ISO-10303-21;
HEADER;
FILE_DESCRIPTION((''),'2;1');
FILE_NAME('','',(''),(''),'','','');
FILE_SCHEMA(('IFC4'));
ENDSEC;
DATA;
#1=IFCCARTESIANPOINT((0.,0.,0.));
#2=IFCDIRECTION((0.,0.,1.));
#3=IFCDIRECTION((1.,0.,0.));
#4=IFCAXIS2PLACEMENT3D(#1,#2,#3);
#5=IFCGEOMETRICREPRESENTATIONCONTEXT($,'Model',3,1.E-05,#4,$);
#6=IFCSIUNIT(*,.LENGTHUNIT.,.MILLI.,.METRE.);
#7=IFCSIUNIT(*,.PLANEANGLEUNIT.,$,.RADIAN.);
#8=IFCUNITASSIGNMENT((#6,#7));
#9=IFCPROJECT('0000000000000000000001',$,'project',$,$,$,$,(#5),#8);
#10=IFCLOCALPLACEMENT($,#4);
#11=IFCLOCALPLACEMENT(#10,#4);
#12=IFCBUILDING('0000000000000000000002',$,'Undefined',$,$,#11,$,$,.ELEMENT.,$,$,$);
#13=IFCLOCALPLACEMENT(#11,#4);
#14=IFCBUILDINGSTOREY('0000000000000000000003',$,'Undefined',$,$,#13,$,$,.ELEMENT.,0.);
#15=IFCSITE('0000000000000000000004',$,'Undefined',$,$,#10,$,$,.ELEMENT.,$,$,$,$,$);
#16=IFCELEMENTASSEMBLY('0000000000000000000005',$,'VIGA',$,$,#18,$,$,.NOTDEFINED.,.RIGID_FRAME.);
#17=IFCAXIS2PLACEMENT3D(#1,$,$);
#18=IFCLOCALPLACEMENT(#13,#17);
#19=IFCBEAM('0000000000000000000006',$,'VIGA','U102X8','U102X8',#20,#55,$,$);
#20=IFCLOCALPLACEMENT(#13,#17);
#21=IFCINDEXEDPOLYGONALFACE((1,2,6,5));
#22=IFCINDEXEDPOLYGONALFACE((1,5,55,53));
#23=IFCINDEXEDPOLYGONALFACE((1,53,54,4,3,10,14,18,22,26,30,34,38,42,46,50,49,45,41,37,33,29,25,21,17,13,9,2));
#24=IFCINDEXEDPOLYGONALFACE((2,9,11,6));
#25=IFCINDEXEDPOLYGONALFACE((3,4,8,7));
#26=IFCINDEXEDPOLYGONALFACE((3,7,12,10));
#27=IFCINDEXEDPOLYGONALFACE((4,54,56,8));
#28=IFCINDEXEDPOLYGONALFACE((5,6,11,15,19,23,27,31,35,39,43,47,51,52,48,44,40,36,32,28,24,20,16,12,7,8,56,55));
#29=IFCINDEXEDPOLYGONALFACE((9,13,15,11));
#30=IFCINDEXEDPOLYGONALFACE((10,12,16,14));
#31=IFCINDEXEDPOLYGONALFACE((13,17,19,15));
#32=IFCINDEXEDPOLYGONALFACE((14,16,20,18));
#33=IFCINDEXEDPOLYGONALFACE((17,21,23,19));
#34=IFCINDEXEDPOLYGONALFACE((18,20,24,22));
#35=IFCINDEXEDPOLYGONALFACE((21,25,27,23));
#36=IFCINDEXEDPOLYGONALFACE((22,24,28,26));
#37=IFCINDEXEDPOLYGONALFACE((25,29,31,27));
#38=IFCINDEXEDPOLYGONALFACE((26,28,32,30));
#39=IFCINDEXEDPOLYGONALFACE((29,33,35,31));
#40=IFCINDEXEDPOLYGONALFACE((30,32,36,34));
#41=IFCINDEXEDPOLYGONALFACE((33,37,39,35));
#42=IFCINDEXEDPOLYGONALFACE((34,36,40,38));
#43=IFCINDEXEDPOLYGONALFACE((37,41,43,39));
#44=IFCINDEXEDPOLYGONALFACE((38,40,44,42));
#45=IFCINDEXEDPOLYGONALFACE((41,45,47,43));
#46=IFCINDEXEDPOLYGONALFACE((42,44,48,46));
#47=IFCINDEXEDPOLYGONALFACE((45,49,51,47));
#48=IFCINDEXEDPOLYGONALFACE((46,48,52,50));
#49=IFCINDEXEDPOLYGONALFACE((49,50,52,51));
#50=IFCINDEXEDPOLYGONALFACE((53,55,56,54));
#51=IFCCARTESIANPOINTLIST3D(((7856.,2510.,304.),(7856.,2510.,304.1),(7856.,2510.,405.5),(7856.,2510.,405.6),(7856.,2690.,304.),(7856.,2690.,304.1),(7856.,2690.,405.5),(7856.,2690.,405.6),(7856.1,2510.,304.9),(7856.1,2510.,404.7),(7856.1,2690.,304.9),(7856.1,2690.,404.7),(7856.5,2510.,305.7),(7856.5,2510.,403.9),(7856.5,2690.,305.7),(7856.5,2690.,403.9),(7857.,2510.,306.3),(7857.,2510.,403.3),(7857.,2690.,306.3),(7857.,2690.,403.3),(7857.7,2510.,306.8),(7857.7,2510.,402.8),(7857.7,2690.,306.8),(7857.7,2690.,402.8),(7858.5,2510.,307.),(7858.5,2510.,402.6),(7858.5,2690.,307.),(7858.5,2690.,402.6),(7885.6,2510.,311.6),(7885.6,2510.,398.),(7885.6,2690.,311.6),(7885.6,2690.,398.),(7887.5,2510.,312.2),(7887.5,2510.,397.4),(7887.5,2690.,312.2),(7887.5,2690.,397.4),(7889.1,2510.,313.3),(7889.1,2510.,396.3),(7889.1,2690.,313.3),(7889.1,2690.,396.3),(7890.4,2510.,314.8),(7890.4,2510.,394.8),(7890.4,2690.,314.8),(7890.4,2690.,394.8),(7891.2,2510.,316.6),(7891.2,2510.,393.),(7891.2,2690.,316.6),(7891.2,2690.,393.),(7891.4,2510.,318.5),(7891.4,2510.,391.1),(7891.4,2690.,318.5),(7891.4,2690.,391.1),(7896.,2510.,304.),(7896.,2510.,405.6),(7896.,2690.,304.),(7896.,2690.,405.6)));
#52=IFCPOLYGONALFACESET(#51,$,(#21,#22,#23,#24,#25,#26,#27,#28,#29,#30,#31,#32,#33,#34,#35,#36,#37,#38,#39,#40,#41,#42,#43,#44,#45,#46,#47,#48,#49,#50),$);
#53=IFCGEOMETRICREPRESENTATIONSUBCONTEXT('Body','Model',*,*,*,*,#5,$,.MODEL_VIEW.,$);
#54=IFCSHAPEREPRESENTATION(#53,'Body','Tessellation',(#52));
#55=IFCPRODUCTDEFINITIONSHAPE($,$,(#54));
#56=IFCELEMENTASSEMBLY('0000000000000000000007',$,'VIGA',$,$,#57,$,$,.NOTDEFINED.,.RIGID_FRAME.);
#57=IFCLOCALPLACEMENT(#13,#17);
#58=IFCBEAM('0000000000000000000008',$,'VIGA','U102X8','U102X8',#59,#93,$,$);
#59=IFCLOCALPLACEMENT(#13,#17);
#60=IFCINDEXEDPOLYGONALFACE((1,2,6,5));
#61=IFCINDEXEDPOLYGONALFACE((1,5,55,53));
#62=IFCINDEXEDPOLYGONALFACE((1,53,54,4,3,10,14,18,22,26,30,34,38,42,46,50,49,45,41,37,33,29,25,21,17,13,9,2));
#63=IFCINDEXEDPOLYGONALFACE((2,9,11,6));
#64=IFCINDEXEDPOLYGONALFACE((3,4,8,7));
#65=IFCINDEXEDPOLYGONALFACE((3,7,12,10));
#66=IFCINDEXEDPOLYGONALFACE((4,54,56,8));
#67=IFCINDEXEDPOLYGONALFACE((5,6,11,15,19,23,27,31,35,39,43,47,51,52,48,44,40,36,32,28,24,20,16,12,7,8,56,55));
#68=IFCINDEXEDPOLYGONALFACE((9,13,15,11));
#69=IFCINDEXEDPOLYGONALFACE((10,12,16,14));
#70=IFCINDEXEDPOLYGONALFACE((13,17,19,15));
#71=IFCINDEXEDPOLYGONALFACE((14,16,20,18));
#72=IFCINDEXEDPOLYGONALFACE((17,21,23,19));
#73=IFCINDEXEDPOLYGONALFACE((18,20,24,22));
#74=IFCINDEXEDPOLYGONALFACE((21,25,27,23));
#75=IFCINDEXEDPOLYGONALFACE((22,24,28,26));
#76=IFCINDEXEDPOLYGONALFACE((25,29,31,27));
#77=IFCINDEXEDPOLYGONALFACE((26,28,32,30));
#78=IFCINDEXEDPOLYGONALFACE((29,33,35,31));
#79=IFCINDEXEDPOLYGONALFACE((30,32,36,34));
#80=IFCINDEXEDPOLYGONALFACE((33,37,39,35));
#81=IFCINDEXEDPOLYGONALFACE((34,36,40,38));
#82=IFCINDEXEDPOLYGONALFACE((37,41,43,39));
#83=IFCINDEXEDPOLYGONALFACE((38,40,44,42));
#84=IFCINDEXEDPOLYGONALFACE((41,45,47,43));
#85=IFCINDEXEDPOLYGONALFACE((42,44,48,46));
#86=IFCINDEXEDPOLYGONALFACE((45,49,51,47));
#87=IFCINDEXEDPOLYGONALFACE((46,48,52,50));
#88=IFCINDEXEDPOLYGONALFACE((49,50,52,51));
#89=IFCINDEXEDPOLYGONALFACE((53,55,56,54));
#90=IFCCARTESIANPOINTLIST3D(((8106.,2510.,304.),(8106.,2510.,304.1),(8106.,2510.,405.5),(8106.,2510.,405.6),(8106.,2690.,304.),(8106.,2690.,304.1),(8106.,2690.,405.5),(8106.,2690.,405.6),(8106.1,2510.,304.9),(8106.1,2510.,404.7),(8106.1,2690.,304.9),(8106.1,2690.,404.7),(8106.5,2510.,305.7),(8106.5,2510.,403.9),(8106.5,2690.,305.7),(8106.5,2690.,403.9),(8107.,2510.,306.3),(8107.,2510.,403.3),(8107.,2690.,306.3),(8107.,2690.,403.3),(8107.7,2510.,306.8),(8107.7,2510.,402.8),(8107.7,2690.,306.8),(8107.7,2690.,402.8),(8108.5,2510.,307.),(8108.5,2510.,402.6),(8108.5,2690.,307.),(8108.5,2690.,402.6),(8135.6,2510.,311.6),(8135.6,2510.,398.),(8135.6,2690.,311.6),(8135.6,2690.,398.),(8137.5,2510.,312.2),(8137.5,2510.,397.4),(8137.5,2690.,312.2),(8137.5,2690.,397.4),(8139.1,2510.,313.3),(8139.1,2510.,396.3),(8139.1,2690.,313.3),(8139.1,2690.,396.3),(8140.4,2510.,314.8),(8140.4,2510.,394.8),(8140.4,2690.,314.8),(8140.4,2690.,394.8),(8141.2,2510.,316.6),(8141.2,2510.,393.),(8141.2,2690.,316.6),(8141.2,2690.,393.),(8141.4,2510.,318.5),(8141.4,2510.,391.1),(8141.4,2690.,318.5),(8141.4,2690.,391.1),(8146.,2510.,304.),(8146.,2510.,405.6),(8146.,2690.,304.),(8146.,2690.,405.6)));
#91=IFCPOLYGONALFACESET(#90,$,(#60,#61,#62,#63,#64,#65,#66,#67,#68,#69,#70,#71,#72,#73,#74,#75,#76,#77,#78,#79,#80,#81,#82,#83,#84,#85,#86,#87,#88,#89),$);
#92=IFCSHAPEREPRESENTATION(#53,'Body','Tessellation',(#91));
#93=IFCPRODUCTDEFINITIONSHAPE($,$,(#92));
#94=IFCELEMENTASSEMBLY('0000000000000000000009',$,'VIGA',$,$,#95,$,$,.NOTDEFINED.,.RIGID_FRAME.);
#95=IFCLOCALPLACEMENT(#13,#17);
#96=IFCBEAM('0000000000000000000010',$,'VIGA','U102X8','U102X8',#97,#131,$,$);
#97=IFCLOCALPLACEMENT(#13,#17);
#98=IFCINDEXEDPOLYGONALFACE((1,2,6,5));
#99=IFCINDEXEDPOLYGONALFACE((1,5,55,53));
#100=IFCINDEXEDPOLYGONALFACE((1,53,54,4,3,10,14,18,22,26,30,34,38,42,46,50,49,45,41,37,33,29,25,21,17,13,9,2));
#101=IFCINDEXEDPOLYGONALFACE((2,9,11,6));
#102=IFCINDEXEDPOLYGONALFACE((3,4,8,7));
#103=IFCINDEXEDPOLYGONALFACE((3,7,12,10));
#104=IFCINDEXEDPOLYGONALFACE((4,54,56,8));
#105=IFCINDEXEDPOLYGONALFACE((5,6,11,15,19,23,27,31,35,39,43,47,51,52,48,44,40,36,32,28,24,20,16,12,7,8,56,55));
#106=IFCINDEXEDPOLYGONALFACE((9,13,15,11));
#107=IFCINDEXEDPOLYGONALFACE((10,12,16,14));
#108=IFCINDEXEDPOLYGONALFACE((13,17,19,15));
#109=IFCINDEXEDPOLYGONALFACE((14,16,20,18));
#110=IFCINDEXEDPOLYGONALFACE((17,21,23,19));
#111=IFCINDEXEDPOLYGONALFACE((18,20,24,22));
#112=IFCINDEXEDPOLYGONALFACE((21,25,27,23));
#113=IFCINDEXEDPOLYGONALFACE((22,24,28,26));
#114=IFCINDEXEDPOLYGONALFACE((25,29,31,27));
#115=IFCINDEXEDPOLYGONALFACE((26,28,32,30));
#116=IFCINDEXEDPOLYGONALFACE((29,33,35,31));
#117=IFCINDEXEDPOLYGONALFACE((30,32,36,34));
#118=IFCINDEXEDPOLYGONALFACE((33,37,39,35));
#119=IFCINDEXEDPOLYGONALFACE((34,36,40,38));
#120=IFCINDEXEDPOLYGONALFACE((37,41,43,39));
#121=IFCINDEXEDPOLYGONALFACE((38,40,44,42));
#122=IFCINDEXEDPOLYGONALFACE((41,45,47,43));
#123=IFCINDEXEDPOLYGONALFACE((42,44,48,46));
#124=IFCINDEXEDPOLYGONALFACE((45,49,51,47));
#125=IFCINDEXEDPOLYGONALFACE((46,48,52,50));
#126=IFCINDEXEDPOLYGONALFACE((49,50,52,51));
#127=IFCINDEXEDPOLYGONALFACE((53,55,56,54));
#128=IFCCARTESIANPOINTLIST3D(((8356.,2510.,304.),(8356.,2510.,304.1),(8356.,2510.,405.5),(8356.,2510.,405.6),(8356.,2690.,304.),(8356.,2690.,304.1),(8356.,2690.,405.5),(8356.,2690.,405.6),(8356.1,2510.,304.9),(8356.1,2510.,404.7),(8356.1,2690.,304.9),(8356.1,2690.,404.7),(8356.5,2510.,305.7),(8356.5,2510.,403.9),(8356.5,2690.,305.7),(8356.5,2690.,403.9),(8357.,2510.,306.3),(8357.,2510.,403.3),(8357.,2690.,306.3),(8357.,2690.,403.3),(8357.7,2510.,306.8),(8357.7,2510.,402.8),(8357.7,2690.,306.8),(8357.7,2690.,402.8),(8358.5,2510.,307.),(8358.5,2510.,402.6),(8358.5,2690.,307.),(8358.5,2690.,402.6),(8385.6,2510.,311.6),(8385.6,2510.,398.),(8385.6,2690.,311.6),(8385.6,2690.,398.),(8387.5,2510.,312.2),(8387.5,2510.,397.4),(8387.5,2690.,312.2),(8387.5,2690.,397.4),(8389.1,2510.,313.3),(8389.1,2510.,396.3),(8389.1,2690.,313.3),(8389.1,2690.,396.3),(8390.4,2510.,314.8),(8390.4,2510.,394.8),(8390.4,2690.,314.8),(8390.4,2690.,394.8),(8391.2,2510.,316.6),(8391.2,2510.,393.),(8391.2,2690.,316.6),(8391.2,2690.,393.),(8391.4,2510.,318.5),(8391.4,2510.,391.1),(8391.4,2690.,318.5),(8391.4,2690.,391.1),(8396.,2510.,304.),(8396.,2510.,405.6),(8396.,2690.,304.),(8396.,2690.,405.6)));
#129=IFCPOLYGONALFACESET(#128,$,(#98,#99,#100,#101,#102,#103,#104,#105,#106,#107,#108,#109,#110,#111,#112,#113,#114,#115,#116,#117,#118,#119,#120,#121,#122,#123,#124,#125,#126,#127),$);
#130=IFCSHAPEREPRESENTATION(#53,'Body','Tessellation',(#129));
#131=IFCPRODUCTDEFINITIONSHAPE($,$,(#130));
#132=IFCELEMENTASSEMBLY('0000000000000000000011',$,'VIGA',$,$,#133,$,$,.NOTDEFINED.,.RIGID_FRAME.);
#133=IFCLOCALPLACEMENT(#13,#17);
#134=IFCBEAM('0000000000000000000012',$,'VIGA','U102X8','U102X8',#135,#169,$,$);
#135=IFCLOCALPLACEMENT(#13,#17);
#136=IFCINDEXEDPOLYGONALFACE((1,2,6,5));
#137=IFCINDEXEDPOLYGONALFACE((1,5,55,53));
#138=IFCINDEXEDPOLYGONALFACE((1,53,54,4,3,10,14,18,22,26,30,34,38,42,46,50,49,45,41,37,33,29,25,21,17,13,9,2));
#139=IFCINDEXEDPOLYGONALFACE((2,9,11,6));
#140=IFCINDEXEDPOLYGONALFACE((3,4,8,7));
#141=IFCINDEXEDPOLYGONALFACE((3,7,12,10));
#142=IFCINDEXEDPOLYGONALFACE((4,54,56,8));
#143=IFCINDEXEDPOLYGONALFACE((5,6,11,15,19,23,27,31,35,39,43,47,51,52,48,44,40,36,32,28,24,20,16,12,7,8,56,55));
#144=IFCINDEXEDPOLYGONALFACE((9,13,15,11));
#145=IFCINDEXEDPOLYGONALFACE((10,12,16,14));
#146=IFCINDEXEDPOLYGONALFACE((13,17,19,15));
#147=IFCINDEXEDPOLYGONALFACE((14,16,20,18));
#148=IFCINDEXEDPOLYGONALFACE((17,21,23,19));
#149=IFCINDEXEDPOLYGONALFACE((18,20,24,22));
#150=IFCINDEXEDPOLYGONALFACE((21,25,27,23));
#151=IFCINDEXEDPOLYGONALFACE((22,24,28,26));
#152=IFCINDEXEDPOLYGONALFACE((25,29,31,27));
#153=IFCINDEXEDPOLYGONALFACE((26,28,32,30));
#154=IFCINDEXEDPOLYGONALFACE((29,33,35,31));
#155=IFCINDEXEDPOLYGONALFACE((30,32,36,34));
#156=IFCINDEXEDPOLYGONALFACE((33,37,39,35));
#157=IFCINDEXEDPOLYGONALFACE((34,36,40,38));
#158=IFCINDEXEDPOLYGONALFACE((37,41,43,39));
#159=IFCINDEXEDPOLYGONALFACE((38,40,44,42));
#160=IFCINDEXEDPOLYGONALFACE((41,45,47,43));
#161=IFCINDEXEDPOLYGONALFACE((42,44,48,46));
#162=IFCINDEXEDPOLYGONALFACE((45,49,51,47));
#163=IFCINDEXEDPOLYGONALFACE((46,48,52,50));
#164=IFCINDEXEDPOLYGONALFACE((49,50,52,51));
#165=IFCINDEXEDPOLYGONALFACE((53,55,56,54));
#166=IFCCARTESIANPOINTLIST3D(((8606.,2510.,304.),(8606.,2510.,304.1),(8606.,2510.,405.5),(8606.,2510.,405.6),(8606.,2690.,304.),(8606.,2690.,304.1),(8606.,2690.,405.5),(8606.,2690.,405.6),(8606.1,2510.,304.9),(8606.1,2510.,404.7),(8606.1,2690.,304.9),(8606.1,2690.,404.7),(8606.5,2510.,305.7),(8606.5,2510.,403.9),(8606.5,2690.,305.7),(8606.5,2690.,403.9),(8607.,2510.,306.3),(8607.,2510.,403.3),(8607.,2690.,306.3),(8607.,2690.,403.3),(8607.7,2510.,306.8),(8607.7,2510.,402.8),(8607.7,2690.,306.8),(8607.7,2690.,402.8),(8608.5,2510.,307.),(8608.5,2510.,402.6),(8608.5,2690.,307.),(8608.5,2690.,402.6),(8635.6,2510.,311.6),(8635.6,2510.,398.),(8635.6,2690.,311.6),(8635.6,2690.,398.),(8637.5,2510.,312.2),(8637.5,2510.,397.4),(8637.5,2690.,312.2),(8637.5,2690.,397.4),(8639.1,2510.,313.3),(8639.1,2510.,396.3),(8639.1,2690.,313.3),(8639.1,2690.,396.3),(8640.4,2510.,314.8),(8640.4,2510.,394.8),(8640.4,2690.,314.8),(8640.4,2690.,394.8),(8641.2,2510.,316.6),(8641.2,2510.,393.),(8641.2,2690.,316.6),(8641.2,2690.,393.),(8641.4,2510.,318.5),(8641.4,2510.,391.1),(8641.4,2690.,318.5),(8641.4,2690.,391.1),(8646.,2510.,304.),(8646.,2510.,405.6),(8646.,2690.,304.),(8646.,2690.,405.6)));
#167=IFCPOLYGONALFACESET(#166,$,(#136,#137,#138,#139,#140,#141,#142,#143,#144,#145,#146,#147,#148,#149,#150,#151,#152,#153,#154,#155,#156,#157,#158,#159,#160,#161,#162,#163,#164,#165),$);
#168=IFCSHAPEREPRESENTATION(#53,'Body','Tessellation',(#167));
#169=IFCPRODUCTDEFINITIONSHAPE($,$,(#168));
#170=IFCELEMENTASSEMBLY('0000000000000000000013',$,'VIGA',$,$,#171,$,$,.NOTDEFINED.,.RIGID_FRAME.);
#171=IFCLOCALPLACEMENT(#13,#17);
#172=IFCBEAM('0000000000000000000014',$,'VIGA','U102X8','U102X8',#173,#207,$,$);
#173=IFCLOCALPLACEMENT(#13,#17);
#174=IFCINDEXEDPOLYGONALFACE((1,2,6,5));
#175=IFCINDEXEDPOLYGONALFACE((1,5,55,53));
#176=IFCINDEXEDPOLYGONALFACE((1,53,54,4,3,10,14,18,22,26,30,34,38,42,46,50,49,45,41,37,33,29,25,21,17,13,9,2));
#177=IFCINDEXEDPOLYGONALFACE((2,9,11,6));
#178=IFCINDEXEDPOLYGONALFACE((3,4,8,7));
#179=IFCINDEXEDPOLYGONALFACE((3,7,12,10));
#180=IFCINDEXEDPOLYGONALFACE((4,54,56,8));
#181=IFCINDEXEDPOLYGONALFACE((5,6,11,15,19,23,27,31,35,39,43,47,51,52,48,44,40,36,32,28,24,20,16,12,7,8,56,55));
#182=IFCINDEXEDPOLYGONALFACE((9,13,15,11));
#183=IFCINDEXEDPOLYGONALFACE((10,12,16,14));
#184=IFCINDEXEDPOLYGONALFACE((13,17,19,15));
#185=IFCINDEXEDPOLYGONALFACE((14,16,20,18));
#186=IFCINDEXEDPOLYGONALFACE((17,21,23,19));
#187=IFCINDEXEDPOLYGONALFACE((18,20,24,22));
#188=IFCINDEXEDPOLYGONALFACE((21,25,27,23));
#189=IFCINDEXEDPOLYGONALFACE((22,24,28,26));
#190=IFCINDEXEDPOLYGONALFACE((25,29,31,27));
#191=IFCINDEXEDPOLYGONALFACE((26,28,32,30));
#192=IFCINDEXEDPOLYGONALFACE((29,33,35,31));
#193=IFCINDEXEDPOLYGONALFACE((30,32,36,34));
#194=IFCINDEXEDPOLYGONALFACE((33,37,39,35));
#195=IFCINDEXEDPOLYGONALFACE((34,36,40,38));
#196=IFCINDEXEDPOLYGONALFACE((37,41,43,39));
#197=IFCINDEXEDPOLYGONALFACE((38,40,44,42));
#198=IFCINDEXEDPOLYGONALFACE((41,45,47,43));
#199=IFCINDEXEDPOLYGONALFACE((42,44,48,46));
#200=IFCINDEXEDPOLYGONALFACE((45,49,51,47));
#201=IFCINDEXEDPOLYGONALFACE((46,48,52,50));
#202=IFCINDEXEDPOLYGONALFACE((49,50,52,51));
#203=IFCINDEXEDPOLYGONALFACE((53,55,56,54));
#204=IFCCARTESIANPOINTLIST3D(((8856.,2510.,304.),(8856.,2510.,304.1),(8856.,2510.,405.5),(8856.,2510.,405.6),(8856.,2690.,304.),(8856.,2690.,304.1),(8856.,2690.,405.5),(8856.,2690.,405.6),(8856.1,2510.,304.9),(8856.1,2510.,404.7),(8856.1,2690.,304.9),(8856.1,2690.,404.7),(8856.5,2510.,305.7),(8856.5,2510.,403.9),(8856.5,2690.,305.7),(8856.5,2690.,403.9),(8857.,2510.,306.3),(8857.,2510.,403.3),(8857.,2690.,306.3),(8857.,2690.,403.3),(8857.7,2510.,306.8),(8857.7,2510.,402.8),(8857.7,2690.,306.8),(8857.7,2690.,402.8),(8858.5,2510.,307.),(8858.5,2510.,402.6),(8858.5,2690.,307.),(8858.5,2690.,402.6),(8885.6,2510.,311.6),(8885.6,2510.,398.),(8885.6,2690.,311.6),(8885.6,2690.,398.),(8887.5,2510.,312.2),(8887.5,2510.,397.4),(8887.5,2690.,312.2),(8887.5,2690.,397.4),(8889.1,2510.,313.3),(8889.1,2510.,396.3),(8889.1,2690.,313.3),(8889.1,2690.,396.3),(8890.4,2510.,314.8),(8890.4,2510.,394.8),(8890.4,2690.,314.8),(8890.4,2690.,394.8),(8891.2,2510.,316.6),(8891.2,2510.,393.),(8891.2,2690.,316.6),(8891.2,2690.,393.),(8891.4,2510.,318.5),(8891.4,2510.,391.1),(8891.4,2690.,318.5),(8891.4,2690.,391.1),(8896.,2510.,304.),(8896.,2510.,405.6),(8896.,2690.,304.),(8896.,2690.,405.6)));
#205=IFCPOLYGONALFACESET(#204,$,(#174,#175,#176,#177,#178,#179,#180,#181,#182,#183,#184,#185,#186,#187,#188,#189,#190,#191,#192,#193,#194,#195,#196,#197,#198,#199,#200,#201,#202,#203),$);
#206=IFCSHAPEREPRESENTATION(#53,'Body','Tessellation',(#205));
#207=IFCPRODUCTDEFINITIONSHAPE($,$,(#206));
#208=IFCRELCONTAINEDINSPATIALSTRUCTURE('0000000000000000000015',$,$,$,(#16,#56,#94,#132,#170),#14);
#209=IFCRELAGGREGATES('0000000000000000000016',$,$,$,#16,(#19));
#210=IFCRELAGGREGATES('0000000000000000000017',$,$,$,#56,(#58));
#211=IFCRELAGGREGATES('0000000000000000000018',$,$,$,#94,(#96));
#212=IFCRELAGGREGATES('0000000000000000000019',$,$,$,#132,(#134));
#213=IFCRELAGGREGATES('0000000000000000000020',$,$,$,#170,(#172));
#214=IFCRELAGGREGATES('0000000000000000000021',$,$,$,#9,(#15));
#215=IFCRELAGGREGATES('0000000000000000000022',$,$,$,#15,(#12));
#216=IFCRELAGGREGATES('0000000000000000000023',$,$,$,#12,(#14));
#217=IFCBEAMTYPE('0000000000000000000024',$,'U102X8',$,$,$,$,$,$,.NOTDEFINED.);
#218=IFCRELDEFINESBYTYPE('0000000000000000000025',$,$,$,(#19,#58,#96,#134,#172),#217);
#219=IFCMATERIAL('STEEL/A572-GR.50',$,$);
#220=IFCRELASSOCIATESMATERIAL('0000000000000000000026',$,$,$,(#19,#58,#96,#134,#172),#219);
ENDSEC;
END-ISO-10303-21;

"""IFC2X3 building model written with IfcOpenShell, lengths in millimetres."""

from ifc_helpers import new_model, si_unit, frame, origin_with_axes, origin_2d_with_axis, place, context, subcontext, project, spatial, u_section, extrude, material, type_object, element, aggregate, save


model = new_model("IFC2X3")

# Units and contexts
model_context = context("Model", 3, precision=1e-05, world=origin_with_axes())
body_context = subcontext(model_context, "Body", "Model", "MODEL_VIEW")
ifc_project = project(units=[si_unit("LENGTHUNIT", "METRE", prefix="MILLI"), si_unit("PLANEANGLEUNIT", "RADIAN")], contexts=[model_context])

# Site, building, storey
site_placement = place(None, origin_with_axes())
site = spatial("IfcSite", under=ifc_project, at=site_placement, Name="Undefined", CompositionType="ELEMENT")
building_placement = place(site_placement, origin_with_axes())
building = spatial("IfcBuilding", under=site, at=building_placement, Name="Undefined", CompositionType="ELEMENT")
storey_placement = place(building_placement, origin_with_axes())
storey = spatial("IfcBuildingStorey", under=building, at=storey_placement, Name="Undefined", CompositionType="ELEMENT", Elevation=0.0)

# Element assemblies, beams
assembly_1_placement = place(storey_placement, origin_with_axes())
assembly_1 = element("IfcElementAssembly", 1, at=assembly_1_placement, inside=storey, Name="VIGA", AssemblyPlace="NOTDEFINED", PredefinedType="RIGID_FRAME")
ifc_material_1 = material(Name="STEEL/A572-GR.50")
beam_type_1 = type_object("IfcBeamType", Name="U102X8", PredefinedType="NOTDEFINED")
beam_1_placement = place(assembly_1_placement, frame((7876.0, 2690.0, 354.8), z_axis=(0.0, 0.0, 1.0), x_axis=(0.0, -1.0, 0.0)))
beam_1 = element("IfcBeam", 2, at=beam_1_placement, type_object=beam_type_1, material=ifc_material_1, Name="VIGA", Description="U102X8", ObjectType="U102X8", context=body_context, shape_type="SweptSolid", body=[
    extrude(u_section(Depth=101.6, FlangeWidth=40.0, WebThickness=4.6, FlangeThickness=6.0, FilletRadius=7.0, EdgeRadius=3.0, FlangeSlope=0.16839, at=origin_2d_with_axis()), frame((180.0, 0.0, 0.0), z_axis=(-1.0, 0.0, 0.0), x_axis=(0.0, -1.0, 0.0)), (0.0, 0.0, 1.0), 180.0),
])
aggregate(assembly_1, [beam_1])
assembly_2_placement = place(storey_placement, origin_with_axes())
assembly_2 = element("IfcElementAssembly", 3, at=assembly_2_placement, inside=storey, Name="VIGA", AssemblyPlace="NOTDEFINED", PredefinedType="RIGID_FRAME")
beam_2_placement = place(assembly_2_placement, frame((8126.0, 2690.0, 354.8), z_axis=(0.0, 0.0, 1.0), x_axis=(0.0, -1.0, 0.0)))
beam_2 = element("IfcBeam", 4, at=beam_2_placement, type_object=beam_type_1, material=ifc_material_1, Name="VIGA", Description="U102X8", ObjectType="U102X8", context=body_context, shape_type="SweptSolid", body=[
    extrude(u_section(Depth=101.6, FlangeWidth=40.0, WebThickness=4.6, FlangeThickness=6.0, FilletRadius=7.0, EdgeRadius=3.0, FlangeSlope=0.16839, at=origin_2d_with_axis()), frame((180.0, 0.0, 0.0), z_axis=(-1.0, 0.0, 0.0), x_axis=(0.0, -1.0, 0.0)), (0.0, 0.0, 1.0), 180.0),
])
aggregate(assembly_2, [beam_2])
assembly_3_placement = place(storey_placement, origin_with_axes())
assembly_3 = element("IfcElementAssembly", 5, at=assembly_3_placement, inside=storey, Name="VIGA", AssemblyPlace="NOTDEFINED", PredefinedType="RIGID_FRAME")
beam_3_placement = place(assembly_3_placement, frame((8376.0, 2690.0, 354.8), z_axis=(0.0, 0.0, 1.0), x_axis=(0.0, -1.0, 0.0)))
beam_3 = element("IfcBeam", 6, at=beam_3_placement, type_object=beam_type_1, material=ifc_material_1, Name="VIGA", Description="U102X8", ObjectType="U102X8", context=body_context, shape_type="SweptSolid", body=[
    extrude(u_section(Depth=101.6, FlangeWidth=40.0, WebThickness=4.6, FlangeThickness=6.0, FilletRadius=7.0, EdgeRadius=3.0, FlangeSlope=0.16839, at=origin_2d_with_axis()), frame((180.0, 0.0, 0.0), z_axis=(-1.0, 0.0, 0.0), x_axis=(0.0, -1.0, 0.0)), (0.0, 0.0, 1.0), 180.0),
])
aggregate(assembly_3, [beam_3])
assembly_4_placement = place(storey_placement, origin_with_axes())
assembly_4 = element("IfcElementAssembly", 7, at=assembly_4_placement, inside=storey, Name="VIGA", AssemblyPlace="NOTDEFINED", PredefinedType="RIGID_FRAME")
beam_4_placement = place(assembly_4_placement, frame((8626.0, 2690.0, 354.8), z_axis=(0.0, 0.0, 1.0), x_axis=(0.0, -1.0, 0.0)))
beam_4 = element("IfcBeam", 8, at=beam_4_placement, type_object=beam_type_1, material=ifc_material_1, Name="VIGA", Description="U102X8", ObjectType="U102X8", context=body_context, shape_type="SweptSolid", body=[
    extrude(u_section(Depth=101.6, FlangeWidth=40.0, WebThickness=4.6, FlangeThickness=6.0, FilletRadius=7.0, EdgeRadius=3.0, FlangeSlope=0.16839, at=origin_2d_with_axis()), frame((180.0, 0.0, 0.0), z_axis=(-1.0, 0.0, 0.0), x_axis=(0.0, -1.0, 0.0)), (0.0, 0.0, 1.0), 180.0),
])
aggregate(assembly_4, [beam_4])
assembly_5_placement = place(storey_placement, origin_with_axes())
assembly_5 = element("IfcElementAssembly", 9, at=assembly_5_placement, inside=storey, Name="VIGA", AssemblyPlace="NOTDEFINED", PredefinedType="RIGID_FRAME")
beam_5_placement = place(assembly_5_placement, frame((8876.0, 2690.0, 354.8), z_axis=(0.0, 0.0, 1.0), x_axis=(0.0, -1.0, 0.0)))
beam_5 = element("IfcBeam", 10, at=beam_5_placement, type_object=beam_type_1, material=ifc_material_1, Name="VIGA", Description="U102X8", ObjectType="U102X8", context=body_context, shape_type="SweptSolid", body=[
    extrude(u_section(Depth=101.6, FlangeWidth=40.0, WebThickness=4.6, FlangeThickness=6.0, FilletRadius=7.0, EdgeRadius=3.0, FlangeSlope=0.16839, at=origin_2d_with_axis()), frame((180.0, 0.0, 0.0), z_axis=(-1.0, 0.0, 0.0), x_axis=(0.0, -1.0, 0.0)), (0.0, 0.0, 1.0), 180.0),
])
aggregate(assembly_5, [beam_5])

save(model, "model.ifc")
